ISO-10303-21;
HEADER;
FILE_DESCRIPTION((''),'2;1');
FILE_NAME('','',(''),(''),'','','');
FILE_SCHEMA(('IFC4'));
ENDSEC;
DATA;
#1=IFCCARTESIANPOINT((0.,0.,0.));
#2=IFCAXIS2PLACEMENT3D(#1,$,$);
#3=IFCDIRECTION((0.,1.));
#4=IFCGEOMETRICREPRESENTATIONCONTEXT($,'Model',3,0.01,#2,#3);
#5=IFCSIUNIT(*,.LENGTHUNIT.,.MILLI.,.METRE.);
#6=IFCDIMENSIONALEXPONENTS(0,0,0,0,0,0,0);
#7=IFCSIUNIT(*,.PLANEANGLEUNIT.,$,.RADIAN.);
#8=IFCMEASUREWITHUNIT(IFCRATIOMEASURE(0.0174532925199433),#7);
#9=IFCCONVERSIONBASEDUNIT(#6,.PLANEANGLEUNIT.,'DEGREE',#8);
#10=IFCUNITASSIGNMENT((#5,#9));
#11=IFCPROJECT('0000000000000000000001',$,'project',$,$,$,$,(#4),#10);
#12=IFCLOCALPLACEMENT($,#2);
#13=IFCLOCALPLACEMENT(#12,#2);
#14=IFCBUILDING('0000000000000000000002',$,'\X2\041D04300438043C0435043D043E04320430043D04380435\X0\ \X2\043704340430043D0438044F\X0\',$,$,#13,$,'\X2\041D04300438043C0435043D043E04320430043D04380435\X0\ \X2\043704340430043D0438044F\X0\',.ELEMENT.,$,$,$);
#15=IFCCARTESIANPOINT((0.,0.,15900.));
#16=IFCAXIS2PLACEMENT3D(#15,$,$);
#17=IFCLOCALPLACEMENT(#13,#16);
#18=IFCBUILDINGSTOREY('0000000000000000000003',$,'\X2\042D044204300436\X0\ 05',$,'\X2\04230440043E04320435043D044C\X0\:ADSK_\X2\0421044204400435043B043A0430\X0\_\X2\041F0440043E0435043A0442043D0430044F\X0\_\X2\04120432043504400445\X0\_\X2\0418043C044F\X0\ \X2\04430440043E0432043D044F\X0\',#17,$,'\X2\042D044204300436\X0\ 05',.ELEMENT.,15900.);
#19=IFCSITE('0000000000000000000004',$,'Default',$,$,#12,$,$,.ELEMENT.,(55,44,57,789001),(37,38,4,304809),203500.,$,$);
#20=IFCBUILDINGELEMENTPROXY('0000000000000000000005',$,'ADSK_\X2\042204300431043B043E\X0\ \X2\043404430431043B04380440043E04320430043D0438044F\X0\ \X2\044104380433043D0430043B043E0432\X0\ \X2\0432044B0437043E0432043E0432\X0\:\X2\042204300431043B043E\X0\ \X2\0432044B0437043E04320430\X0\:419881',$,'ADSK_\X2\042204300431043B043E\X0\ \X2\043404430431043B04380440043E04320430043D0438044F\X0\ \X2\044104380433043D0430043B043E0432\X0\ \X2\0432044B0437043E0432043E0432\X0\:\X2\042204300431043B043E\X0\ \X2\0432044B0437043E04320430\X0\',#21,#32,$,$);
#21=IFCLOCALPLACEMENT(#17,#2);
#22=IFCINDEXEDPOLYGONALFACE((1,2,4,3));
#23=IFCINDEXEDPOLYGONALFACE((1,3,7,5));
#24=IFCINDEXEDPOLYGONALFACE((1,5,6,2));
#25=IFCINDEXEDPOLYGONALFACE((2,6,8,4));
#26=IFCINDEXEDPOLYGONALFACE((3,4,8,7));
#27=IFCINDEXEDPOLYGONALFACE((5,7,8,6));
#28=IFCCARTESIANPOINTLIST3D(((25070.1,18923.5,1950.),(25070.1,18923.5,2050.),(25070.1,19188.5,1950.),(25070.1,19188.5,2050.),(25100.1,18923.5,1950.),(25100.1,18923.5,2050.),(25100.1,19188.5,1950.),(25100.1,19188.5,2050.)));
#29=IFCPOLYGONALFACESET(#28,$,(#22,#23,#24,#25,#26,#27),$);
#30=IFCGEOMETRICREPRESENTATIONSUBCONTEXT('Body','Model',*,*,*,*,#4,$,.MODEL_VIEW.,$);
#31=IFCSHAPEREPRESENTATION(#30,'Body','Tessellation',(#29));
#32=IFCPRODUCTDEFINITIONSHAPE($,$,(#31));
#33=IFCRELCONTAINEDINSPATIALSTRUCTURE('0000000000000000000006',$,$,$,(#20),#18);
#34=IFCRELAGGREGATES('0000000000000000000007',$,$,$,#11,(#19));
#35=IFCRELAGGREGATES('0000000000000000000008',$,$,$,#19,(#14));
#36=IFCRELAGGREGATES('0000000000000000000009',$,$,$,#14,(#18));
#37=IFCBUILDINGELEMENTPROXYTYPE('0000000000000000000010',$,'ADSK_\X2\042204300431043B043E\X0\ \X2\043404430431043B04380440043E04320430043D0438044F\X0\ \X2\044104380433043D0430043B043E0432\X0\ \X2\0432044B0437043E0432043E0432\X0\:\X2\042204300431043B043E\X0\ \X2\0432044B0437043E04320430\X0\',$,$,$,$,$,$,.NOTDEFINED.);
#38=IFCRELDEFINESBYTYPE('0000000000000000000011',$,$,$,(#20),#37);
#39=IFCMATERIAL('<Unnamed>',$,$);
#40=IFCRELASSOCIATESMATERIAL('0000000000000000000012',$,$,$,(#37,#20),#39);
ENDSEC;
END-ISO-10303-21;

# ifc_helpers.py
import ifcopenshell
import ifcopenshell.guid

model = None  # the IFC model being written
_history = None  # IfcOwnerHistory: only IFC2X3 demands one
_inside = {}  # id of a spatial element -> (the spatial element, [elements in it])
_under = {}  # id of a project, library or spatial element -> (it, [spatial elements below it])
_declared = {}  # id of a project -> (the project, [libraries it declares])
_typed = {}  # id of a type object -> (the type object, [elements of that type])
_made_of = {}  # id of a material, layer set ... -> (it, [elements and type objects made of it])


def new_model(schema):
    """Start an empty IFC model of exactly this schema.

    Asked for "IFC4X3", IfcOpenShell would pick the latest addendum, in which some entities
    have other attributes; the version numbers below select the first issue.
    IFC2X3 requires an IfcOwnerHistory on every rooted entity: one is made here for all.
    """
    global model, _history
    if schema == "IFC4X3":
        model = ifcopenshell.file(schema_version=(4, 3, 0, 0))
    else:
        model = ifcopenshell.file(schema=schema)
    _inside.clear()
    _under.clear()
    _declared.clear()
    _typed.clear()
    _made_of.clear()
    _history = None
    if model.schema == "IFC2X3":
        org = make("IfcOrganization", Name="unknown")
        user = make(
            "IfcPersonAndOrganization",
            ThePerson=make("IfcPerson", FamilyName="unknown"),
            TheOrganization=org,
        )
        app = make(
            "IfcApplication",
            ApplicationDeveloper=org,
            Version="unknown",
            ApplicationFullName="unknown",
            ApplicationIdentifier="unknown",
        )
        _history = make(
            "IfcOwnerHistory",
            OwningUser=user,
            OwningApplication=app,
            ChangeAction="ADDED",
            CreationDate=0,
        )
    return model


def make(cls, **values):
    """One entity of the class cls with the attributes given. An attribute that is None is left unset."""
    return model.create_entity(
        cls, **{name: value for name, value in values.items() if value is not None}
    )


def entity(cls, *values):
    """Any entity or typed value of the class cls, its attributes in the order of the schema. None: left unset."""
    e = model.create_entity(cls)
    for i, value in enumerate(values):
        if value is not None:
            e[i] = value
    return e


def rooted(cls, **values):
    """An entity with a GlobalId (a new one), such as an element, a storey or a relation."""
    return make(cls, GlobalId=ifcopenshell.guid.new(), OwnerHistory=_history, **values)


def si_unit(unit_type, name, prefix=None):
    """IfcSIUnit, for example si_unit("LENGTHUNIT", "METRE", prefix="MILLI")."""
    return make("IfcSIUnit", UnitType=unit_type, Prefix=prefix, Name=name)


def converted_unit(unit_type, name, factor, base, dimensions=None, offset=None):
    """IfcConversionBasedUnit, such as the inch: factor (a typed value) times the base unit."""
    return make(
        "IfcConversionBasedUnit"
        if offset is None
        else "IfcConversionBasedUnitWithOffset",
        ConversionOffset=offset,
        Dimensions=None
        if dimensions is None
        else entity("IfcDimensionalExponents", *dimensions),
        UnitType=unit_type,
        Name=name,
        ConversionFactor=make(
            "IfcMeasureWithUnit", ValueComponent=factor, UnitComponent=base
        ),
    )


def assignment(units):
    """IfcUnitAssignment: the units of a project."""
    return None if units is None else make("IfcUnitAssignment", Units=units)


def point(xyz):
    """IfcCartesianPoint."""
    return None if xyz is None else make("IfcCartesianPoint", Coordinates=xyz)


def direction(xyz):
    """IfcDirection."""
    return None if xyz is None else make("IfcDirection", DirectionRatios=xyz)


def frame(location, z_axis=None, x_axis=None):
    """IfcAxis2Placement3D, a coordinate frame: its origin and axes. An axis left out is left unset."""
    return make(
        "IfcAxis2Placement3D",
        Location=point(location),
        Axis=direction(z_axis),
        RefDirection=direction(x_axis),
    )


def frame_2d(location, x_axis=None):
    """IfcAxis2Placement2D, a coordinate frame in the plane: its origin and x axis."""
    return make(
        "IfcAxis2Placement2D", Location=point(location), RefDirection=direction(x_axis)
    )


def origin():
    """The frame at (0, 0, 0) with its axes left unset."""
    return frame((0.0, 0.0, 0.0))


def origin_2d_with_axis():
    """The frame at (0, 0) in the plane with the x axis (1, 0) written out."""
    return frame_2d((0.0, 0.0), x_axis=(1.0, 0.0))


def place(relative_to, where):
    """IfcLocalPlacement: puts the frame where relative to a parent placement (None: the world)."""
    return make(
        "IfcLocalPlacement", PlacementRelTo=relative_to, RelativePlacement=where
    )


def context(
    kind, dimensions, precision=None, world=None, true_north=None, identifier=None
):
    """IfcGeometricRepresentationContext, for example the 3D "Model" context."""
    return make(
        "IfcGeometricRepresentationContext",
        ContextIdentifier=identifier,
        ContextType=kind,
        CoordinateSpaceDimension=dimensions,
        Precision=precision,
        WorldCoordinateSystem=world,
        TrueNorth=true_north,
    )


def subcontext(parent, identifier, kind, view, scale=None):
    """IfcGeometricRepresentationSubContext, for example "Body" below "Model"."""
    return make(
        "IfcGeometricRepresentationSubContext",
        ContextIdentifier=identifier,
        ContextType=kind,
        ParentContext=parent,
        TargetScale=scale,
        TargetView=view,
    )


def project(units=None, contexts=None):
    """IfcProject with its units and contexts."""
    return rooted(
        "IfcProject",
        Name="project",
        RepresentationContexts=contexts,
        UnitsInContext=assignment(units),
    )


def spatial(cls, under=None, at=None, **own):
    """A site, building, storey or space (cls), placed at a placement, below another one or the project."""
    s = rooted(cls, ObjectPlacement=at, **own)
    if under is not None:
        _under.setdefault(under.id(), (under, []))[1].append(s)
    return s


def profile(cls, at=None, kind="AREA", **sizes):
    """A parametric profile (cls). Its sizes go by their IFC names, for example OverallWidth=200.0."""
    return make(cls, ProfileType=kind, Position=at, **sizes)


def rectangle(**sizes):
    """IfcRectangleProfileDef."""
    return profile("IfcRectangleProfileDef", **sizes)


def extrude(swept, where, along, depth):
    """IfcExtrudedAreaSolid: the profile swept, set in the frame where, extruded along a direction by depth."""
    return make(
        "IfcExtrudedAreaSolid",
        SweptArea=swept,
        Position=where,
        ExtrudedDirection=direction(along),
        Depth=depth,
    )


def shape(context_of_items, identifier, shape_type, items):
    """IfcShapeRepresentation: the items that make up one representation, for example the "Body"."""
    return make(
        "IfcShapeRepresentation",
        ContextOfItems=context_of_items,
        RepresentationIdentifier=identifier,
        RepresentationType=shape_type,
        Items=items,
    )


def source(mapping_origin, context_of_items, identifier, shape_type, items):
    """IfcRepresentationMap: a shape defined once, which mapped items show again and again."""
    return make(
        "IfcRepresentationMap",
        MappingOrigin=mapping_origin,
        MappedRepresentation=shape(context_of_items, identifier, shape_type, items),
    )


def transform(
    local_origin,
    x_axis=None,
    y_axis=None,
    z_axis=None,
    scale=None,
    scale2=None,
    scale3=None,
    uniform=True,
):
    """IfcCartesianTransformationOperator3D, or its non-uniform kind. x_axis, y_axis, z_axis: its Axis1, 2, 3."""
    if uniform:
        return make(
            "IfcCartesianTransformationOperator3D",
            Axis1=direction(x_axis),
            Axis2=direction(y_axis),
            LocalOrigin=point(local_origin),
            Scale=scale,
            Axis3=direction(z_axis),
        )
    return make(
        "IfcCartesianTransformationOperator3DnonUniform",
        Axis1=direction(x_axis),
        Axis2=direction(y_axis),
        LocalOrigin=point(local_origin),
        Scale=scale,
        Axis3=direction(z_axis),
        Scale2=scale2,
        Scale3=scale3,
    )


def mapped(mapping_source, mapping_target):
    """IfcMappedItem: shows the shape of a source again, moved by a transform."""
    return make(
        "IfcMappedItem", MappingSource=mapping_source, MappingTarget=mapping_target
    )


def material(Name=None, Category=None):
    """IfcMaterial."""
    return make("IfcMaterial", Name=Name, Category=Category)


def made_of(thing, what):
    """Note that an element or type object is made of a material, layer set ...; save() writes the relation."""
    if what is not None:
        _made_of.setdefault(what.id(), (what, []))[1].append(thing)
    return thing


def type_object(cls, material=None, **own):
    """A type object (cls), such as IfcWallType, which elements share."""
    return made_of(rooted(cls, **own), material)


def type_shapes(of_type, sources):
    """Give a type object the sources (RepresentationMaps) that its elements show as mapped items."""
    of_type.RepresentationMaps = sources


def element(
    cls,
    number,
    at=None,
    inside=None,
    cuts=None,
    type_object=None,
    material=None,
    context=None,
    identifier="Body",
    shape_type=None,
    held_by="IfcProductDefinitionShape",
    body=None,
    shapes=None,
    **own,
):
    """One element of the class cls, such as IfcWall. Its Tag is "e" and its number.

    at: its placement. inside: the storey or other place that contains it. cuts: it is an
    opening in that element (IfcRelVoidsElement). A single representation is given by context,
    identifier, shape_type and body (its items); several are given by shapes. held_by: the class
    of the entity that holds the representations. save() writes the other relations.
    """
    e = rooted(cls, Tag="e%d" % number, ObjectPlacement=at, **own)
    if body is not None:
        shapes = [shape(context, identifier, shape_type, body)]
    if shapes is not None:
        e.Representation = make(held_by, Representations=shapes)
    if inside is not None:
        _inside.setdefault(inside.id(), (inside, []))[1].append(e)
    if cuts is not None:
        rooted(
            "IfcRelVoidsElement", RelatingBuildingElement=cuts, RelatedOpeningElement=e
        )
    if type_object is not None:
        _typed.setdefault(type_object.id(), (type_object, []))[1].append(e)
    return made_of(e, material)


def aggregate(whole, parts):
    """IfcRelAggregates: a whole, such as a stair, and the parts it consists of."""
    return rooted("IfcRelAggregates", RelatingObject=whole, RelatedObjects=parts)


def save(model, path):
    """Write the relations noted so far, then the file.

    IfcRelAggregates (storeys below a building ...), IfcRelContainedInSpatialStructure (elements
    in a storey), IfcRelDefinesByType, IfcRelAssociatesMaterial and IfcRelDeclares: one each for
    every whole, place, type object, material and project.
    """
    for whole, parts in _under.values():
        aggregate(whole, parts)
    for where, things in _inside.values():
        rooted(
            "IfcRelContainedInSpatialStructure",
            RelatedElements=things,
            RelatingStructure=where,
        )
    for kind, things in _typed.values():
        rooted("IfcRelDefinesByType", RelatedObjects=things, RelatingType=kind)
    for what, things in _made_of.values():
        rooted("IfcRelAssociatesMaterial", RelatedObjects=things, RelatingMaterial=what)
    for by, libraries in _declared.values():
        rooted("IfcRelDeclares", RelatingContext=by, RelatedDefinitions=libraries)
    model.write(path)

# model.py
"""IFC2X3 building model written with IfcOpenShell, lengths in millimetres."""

from ifc_helpers import new_model, entity, si_unit, converted_unit, direction, frame, origin, origin_2d_with_axis, place, context, subcontext, project, spatial, rectangle, extrude, source, transform, mapped, material, type_object, type_shapes, element, save


model = new_model("IFC2X3")

# Units and contexts
model_context = context("Model", 3, precision=0.01, world=origin(), true_north=direction((0.0, 1.0)))
body_context = subcontext(model_context, "Body", "Model", "MODEL_VIEW")
ifc_project = project(units=[si_unit("LENGTHUNIT", "METRE", prefix="MILLI"), converted_unit("PLANEANGLEUNIT", "DEGREE", entity("IfcRatioMeasure", 0.0174532925199433), si_unit("PLANEANGLEUNIT", "RADIAN"), dimensions=[0, 0, 0, 0, 0, 0, 0])], contexts=[model_context])

# Site, building, storey
site_placement = place(None, origin())
site = spatial("IfcSite", under=ifc_project, at=site_placement, Name="Default", CompositionType="ELEMENT", RefLatitude=(55, 44, 57, 789001), RefLongitude=(37, 38, 4, 304809), RefElevation=203500.0)
building_placement = place(site_placement, origin())
building = spatial("IfcBuilding", under=site, at=building_placement, Name="Наименование здания", LongName="Наименование здания", CompositionType="ELEMENT")
storey_placement = place(building_placement, frame((0.0, 0.0, 15900.0)))
storey = spatial("IfcBuildingStorey", under=building, at=storey_placement, Name="Этаж 05", ObjectType="Уровень:ADSK_Стрелка_Проектная_Вверх_Имя уровня", LongName="Этаж 05", CompositionType="ELEMENT", Elevation=15900.0)

# Building element proxy
ifc_material_1 = material(Name="<Unnamed>")
building_element_proxy_type_1 = type_object("IfcBuildingElementProxyType", Name="ADSK_Табло дублирования сигналов вызовов:Табло вызова", PredefinedType="NOTDEFINED", material=ifc_material_1)
shared_shape_1 = source(origin(), body_context, "Body", "SweptSolid", [
    extrude(rectangle(XDim=265.0, YDim=30.0, at=origin_2d_with_axis()), frame((132.5, 15.0, 0.0), z_axis=(0.0, 0.0, 1.0), x_axis=(-1.0, 0.0, 0.0)), (0.0, 0.0, 1.0), 100.0),
])
type_shapes(building_element_proxy_type_1, [shared_shape_1])
proxy_1_placement = place(storey_placement, frame((25100.1, 18923.5, 1950.0), z_axis=(0.0, 0.0, 1.0), x_axis=(0.0, 1.0, 0.0)))
element("IfcBuildingElementProxy", 1, at=proxy_1_placement, inside=storey, type_object=building_element_proxy_type_1, material=ifc_material_1, Name="ADSK_Табло дублирования сигналов вызовов:Табло вызова:419881", ObjectType="ADSK_Табло дублирования сигналов вызовов:Табло вызова", context=body_context, shape_type="MappedRepresentation", body=[
    mapped(shared_shape_1, transform((0.0, 0.0, 0.0), scale=1.0)),
])

save(model, "model.ifc")
